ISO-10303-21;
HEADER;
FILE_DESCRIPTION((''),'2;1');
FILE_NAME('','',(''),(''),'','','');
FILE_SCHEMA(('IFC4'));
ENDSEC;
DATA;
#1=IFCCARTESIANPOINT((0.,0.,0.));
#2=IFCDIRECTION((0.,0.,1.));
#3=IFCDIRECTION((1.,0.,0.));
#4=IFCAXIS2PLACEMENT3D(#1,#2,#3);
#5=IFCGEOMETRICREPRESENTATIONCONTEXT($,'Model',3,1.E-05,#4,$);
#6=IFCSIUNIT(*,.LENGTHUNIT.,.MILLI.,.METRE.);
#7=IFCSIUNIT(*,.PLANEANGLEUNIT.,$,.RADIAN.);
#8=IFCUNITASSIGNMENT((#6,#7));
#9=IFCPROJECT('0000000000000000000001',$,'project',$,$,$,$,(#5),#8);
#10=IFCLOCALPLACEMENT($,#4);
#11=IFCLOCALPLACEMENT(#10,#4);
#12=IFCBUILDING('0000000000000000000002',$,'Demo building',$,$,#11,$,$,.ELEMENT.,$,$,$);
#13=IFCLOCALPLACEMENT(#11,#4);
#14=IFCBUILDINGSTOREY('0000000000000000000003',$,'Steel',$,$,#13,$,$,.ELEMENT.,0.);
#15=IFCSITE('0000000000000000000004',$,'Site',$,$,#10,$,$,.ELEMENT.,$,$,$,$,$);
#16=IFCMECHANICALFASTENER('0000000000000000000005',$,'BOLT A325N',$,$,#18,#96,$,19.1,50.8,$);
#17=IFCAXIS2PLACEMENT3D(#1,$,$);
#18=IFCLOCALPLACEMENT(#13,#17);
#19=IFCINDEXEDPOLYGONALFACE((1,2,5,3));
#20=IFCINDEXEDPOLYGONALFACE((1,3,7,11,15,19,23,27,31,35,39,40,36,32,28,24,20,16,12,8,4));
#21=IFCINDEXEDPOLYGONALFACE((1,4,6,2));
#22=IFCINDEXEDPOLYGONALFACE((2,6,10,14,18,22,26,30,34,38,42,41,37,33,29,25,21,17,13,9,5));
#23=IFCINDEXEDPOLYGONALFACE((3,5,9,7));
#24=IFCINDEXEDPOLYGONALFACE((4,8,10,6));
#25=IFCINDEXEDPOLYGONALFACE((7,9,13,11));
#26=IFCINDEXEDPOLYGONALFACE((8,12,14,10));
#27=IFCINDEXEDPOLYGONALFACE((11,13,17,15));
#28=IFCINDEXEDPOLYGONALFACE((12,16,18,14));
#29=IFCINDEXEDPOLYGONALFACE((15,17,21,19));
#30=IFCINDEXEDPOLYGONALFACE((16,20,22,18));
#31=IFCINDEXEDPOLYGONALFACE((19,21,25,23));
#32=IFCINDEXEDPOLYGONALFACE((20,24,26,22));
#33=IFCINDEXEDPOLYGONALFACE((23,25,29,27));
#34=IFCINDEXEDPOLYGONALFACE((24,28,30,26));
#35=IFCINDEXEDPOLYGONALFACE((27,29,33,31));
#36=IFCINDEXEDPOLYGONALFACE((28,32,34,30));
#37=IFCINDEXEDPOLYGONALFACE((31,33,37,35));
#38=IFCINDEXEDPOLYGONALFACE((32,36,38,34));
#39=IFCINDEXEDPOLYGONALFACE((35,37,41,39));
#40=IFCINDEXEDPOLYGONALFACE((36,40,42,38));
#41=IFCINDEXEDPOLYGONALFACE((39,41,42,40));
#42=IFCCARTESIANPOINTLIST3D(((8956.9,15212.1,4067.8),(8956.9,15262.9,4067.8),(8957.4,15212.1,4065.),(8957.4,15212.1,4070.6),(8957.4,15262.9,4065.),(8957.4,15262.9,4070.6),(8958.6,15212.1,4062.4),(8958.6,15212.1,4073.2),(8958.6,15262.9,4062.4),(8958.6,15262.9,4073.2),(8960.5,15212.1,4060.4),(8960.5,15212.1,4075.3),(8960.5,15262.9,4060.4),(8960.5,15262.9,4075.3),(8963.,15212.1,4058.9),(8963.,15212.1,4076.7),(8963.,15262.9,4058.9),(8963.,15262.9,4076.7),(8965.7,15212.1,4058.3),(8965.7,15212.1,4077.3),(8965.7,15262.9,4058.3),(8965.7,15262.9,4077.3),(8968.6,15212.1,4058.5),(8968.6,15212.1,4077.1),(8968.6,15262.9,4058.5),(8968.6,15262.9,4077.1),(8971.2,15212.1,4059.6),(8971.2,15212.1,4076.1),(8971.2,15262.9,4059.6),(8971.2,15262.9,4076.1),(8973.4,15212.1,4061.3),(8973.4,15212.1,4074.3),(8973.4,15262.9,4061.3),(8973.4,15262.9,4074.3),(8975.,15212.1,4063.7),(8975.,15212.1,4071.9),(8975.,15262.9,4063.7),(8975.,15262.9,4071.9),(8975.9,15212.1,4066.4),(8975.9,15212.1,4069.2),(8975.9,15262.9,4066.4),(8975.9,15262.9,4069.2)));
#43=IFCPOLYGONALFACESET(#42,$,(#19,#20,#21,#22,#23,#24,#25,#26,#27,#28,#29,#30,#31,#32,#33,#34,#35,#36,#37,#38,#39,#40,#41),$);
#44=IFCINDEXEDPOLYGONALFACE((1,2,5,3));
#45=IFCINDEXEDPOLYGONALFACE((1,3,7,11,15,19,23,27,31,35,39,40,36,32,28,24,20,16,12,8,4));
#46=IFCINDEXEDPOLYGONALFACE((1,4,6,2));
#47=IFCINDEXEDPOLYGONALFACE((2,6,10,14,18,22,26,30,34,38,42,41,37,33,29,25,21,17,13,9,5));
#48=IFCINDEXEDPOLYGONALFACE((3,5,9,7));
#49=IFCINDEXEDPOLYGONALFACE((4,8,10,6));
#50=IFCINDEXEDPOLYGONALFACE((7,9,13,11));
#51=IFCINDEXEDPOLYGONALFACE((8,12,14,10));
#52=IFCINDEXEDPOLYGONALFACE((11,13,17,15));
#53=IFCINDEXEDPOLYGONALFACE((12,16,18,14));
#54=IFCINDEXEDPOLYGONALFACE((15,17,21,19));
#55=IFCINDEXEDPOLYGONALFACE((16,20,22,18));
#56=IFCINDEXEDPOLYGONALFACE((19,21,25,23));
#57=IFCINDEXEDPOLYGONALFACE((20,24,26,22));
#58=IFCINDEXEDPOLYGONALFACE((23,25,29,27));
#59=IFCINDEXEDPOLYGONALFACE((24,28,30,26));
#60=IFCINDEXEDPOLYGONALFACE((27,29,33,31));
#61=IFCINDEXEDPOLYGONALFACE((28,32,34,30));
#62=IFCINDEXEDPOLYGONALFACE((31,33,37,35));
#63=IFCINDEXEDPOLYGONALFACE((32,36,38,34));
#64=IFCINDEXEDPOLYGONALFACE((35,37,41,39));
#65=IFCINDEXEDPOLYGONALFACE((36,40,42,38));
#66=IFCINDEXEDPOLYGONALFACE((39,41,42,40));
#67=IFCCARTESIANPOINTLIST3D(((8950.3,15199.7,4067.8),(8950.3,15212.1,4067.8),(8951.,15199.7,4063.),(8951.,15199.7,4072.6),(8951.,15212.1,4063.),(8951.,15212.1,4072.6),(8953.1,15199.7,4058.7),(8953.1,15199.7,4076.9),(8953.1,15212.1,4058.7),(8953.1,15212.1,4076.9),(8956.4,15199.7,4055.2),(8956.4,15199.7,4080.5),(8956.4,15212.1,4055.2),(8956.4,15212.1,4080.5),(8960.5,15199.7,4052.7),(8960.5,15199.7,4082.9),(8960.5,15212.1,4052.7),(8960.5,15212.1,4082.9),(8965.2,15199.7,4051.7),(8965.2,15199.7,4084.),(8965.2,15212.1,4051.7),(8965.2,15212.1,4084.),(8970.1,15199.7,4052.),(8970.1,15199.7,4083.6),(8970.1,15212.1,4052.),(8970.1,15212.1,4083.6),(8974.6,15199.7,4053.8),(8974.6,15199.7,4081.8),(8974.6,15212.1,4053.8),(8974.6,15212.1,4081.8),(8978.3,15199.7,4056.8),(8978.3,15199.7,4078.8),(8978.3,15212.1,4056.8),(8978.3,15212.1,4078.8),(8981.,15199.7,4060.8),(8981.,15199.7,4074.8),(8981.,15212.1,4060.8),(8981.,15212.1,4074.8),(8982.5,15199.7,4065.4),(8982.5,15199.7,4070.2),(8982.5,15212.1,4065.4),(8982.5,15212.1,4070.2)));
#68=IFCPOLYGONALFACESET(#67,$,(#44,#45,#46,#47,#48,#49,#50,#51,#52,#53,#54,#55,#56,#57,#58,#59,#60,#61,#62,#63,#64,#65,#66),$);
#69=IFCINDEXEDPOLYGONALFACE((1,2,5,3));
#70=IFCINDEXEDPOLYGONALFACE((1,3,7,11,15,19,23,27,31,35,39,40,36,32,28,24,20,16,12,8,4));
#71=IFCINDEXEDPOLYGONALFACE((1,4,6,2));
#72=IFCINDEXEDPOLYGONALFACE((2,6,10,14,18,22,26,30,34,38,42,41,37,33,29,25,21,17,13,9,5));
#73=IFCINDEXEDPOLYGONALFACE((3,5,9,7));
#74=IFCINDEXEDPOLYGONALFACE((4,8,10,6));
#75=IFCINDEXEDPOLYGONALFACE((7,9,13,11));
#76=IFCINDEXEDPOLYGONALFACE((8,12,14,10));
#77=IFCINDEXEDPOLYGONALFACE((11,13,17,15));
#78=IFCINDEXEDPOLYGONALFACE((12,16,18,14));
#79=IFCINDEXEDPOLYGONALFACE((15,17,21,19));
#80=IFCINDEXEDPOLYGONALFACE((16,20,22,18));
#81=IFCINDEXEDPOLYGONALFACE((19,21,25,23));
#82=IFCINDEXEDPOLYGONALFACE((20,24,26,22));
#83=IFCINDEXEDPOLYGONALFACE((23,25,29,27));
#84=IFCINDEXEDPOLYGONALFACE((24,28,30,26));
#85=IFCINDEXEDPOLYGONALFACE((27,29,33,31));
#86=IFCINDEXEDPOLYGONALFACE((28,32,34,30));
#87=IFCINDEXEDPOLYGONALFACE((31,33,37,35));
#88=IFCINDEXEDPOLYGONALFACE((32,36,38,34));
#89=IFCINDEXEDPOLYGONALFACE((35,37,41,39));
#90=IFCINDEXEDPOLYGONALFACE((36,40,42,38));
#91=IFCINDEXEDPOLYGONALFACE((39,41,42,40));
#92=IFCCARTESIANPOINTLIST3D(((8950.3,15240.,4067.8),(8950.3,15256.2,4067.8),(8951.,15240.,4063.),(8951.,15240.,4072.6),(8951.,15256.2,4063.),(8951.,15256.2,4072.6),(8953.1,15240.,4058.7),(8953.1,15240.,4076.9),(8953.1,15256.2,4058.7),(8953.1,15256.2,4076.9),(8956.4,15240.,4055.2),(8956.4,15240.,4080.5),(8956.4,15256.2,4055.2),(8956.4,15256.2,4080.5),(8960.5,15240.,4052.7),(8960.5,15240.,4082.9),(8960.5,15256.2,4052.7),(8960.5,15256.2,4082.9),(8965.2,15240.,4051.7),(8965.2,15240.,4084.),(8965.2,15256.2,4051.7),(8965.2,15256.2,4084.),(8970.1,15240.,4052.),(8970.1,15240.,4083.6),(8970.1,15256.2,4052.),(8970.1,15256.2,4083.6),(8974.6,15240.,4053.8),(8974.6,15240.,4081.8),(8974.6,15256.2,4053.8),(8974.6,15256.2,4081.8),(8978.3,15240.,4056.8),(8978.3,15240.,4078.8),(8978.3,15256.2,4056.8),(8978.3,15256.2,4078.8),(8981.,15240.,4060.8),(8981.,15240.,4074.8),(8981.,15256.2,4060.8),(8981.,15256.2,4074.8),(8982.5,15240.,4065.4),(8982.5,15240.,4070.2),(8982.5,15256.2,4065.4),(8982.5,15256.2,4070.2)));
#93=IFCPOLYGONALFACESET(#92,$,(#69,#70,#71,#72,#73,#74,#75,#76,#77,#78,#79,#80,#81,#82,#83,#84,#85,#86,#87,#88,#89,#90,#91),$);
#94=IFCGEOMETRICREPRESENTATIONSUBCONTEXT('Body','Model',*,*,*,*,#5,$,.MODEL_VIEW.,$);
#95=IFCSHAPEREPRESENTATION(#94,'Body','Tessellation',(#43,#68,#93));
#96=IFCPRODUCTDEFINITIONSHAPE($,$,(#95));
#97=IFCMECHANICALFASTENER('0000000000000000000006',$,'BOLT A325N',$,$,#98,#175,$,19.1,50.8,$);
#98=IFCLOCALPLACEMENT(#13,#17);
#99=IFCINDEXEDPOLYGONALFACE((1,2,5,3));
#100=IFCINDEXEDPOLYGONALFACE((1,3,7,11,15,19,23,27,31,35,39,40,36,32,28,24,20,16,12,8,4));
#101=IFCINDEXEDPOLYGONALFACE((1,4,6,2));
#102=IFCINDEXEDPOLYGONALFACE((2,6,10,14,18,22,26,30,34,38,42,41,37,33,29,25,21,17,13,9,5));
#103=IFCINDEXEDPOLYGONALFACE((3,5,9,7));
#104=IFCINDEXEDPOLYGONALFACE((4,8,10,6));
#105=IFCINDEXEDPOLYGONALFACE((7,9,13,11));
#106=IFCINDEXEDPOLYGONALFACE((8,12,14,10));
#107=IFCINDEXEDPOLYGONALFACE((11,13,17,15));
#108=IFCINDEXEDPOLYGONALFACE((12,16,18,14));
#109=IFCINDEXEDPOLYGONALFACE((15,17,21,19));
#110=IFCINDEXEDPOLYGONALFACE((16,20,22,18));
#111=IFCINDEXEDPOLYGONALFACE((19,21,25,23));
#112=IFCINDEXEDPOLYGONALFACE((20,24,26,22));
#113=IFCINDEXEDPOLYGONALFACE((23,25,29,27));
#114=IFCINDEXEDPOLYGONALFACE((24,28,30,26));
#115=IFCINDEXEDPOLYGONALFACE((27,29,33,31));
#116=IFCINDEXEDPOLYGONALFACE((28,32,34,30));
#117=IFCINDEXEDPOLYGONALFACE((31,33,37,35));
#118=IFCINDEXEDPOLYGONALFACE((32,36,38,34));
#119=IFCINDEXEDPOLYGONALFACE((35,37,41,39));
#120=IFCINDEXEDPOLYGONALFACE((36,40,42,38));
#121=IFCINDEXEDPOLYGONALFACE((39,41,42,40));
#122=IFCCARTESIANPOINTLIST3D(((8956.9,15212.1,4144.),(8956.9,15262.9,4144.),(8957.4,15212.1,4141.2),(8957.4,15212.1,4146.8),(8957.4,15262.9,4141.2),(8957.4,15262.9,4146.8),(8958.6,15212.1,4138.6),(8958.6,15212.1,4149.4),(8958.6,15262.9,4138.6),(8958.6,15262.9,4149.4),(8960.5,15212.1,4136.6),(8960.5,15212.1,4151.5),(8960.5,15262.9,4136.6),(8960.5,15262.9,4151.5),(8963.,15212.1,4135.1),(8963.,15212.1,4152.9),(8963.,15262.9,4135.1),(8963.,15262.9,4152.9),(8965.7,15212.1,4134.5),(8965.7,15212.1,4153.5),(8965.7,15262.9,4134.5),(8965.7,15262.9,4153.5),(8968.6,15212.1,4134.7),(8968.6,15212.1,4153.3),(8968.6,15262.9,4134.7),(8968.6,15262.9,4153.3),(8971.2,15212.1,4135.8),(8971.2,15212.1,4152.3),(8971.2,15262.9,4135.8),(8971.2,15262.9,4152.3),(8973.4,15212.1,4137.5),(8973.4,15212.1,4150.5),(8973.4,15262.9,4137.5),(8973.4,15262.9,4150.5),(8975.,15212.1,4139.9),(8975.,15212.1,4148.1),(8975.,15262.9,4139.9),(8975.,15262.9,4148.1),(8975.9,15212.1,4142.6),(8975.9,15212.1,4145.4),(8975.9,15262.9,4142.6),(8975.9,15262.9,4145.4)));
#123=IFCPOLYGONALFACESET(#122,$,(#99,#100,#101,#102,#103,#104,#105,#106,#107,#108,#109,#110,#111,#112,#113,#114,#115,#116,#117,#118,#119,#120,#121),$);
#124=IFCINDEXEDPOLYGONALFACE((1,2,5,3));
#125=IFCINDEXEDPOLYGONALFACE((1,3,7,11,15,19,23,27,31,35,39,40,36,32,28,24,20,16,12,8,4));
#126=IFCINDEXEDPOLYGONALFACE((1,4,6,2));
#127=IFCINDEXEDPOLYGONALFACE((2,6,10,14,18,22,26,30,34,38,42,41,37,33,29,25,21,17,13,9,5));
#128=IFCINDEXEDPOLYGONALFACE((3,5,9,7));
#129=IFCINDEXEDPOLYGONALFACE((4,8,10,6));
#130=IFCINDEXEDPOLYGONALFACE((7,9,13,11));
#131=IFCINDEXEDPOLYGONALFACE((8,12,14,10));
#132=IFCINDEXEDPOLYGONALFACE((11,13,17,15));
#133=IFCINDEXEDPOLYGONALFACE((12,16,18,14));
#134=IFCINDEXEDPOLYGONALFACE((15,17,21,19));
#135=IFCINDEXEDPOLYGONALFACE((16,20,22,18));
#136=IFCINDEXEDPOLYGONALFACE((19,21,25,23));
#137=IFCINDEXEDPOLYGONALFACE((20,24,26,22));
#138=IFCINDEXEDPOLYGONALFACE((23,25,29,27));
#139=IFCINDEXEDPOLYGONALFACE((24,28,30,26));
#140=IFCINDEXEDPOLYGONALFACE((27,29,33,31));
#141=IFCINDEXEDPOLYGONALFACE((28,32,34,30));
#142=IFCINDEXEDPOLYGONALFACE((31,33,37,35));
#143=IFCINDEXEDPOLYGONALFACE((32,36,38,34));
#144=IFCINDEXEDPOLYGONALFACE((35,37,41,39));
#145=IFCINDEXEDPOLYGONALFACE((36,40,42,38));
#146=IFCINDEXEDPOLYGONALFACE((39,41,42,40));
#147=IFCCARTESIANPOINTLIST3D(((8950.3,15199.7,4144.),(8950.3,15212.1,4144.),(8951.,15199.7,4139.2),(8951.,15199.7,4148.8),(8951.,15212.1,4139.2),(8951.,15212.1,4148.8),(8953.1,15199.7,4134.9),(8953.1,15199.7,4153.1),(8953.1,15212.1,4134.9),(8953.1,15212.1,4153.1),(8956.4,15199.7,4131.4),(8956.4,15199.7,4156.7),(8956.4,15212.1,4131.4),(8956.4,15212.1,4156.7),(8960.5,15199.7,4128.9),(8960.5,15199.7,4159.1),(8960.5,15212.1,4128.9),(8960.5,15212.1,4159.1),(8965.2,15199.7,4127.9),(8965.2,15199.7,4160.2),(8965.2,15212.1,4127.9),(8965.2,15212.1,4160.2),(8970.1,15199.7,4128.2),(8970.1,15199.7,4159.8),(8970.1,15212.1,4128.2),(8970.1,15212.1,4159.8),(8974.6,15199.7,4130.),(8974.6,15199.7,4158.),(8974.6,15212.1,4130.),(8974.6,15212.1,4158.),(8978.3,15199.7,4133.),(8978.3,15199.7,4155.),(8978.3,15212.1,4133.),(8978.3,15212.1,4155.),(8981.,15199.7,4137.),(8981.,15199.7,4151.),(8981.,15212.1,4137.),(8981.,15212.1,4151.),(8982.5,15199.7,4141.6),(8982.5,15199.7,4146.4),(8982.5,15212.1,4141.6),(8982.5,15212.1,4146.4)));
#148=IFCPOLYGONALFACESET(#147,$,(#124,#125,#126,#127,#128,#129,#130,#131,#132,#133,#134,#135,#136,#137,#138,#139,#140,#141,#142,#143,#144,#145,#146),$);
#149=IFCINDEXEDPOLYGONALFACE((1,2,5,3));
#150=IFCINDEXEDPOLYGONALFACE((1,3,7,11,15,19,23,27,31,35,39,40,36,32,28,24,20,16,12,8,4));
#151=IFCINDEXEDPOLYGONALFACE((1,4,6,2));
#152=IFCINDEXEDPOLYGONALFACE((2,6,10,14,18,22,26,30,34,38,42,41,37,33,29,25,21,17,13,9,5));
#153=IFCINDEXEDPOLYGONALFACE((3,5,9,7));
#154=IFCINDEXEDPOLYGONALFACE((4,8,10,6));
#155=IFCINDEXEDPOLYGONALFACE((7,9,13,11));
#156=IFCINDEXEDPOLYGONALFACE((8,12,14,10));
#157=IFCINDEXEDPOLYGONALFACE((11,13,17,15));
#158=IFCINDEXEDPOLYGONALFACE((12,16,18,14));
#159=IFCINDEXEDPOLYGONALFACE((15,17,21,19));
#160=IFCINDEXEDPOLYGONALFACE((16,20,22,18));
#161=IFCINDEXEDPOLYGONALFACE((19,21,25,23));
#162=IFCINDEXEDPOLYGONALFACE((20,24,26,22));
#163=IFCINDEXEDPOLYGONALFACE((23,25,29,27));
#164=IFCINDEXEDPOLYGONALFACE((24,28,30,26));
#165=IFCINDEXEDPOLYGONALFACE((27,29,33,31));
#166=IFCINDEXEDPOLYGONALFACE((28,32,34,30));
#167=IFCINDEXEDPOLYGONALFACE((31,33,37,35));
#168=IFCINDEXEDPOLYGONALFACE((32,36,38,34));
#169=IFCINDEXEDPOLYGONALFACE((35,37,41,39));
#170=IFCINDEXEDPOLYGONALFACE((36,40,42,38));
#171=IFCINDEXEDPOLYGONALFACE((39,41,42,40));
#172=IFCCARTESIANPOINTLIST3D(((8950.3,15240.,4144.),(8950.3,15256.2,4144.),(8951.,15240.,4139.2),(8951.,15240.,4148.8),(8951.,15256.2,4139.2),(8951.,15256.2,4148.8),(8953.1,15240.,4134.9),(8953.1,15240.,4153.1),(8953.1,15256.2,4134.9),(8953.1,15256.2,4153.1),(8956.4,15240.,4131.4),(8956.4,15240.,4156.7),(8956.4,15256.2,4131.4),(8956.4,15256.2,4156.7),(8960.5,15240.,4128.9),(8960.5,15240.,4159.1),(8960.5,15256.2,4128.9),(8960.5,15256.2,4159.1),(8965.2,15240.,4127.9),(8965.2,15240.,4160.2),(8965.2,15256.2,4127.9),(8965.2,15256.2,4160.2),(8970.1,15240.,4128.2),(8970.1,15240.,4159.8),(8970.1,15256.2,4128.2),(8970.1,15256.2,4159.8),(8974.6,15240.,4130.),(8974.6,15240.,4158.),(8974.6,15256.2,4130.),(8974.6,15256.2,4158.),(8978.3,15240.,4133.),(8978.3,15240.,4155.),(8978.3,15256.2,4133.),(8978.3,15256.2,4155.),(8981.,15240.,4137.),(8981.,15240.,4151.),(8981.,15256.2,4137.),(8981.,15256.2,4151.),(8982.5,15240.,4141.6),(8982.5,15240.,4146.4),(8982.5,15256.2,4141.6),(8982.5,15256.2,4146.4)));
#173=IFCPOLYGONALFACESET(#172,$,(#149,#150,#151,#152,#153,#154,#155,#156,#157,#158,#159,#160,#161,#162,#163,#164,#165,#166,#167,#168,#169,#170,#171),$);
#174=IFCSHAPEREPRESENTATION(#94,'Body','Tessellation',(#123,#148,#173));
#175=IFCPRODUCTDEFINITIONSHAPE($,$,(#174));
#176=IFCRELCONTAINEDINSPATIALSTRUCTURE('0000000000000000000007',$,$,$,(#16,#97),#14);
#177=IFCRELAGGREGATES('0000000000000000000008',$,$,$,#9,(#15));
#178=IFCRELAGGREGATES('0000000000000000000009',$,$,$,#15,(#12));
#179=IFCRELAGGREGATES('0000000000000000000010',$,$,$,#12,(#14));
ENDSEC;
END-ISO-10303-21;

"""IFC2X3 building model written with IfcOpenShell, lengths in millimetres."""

from ifc_helpers import new_model, si_unit, frame, origin, origin_with_axes, origin_2d, place, context, subcontext, project, spatial, circle, extrude, element, save


model = new_model("IFC2X3")

# Units and contexts
model_context = context("Model", 3, precision=1e-05, world=origin_with_axes())
body_context = subcontext(model_context, "Body", "Model", "MODEL_VIEW")
ifc_project = project(units=[si_unit("LENGTHUNIT", "METRE", prefix="MILLI"), si_unit("PLANEANGLEUNIT", "RADIAN")], contexts=[model_context])

# Site, building, storey
site_placement = place(None, origin_with_axes())
site = spatial("IfcSite", under=ifc_project, at=site_placement, Name="Site", CompositionType="ELEMENT")
building_placement = place(site_placement, origin_with_axes())
building = spatial("IfcBuilding", under=site, at=building_placement, Name="Demo building", CompositionType="ELEMENT")
placement = place(building_placement, origin_with_axes())
storey = spatial("IfcBuildingStorey", under=building, at=placement, Name="Steel", CompositionType="ELEMENT", Elevation=0.0)

# Mechanical fasteners
for number, where, z_axis, x_axis, name in (
    (1, (8966.5, 15212.1, 4067.8), (0.0, 1.0, 0.0), (-1.0, 0.0, 0.0), "BOLT A325N"),
    (2, (8966.5, 15212.1, 4144.0), (0.0, 1.0, 0.0), (-1.0, 0.0, 0.0), "BOLT A325N"),
):
    element("IfcMechanicalFastener", number, at=place(placement, frame(where, z_axis=z_axis, x_axis=x_axis)), inside=storey, Name=name, NominalDiameter=19.1, NominalLength=50.8, context=body_context, shape_type="SweptSolid", body=[
        extrude(circle(Radius=9.5, at=origin_2d()), origin(), (0.0, 0.0, 1.0), 50.8),
        extrude(circle(Radius=16.2, at=origin_2d()), frame((0.0, 0.0, -12.4)), (0.0, 0.0, 1.0), 12.4),
        extrude(circle(Radius=16.2, at=origin_2d()), frame((0.0, 0.0, 27.9)), (0.0, 0.0, 1.0), 16.2),
    ])

save(model, "model.ifc")
